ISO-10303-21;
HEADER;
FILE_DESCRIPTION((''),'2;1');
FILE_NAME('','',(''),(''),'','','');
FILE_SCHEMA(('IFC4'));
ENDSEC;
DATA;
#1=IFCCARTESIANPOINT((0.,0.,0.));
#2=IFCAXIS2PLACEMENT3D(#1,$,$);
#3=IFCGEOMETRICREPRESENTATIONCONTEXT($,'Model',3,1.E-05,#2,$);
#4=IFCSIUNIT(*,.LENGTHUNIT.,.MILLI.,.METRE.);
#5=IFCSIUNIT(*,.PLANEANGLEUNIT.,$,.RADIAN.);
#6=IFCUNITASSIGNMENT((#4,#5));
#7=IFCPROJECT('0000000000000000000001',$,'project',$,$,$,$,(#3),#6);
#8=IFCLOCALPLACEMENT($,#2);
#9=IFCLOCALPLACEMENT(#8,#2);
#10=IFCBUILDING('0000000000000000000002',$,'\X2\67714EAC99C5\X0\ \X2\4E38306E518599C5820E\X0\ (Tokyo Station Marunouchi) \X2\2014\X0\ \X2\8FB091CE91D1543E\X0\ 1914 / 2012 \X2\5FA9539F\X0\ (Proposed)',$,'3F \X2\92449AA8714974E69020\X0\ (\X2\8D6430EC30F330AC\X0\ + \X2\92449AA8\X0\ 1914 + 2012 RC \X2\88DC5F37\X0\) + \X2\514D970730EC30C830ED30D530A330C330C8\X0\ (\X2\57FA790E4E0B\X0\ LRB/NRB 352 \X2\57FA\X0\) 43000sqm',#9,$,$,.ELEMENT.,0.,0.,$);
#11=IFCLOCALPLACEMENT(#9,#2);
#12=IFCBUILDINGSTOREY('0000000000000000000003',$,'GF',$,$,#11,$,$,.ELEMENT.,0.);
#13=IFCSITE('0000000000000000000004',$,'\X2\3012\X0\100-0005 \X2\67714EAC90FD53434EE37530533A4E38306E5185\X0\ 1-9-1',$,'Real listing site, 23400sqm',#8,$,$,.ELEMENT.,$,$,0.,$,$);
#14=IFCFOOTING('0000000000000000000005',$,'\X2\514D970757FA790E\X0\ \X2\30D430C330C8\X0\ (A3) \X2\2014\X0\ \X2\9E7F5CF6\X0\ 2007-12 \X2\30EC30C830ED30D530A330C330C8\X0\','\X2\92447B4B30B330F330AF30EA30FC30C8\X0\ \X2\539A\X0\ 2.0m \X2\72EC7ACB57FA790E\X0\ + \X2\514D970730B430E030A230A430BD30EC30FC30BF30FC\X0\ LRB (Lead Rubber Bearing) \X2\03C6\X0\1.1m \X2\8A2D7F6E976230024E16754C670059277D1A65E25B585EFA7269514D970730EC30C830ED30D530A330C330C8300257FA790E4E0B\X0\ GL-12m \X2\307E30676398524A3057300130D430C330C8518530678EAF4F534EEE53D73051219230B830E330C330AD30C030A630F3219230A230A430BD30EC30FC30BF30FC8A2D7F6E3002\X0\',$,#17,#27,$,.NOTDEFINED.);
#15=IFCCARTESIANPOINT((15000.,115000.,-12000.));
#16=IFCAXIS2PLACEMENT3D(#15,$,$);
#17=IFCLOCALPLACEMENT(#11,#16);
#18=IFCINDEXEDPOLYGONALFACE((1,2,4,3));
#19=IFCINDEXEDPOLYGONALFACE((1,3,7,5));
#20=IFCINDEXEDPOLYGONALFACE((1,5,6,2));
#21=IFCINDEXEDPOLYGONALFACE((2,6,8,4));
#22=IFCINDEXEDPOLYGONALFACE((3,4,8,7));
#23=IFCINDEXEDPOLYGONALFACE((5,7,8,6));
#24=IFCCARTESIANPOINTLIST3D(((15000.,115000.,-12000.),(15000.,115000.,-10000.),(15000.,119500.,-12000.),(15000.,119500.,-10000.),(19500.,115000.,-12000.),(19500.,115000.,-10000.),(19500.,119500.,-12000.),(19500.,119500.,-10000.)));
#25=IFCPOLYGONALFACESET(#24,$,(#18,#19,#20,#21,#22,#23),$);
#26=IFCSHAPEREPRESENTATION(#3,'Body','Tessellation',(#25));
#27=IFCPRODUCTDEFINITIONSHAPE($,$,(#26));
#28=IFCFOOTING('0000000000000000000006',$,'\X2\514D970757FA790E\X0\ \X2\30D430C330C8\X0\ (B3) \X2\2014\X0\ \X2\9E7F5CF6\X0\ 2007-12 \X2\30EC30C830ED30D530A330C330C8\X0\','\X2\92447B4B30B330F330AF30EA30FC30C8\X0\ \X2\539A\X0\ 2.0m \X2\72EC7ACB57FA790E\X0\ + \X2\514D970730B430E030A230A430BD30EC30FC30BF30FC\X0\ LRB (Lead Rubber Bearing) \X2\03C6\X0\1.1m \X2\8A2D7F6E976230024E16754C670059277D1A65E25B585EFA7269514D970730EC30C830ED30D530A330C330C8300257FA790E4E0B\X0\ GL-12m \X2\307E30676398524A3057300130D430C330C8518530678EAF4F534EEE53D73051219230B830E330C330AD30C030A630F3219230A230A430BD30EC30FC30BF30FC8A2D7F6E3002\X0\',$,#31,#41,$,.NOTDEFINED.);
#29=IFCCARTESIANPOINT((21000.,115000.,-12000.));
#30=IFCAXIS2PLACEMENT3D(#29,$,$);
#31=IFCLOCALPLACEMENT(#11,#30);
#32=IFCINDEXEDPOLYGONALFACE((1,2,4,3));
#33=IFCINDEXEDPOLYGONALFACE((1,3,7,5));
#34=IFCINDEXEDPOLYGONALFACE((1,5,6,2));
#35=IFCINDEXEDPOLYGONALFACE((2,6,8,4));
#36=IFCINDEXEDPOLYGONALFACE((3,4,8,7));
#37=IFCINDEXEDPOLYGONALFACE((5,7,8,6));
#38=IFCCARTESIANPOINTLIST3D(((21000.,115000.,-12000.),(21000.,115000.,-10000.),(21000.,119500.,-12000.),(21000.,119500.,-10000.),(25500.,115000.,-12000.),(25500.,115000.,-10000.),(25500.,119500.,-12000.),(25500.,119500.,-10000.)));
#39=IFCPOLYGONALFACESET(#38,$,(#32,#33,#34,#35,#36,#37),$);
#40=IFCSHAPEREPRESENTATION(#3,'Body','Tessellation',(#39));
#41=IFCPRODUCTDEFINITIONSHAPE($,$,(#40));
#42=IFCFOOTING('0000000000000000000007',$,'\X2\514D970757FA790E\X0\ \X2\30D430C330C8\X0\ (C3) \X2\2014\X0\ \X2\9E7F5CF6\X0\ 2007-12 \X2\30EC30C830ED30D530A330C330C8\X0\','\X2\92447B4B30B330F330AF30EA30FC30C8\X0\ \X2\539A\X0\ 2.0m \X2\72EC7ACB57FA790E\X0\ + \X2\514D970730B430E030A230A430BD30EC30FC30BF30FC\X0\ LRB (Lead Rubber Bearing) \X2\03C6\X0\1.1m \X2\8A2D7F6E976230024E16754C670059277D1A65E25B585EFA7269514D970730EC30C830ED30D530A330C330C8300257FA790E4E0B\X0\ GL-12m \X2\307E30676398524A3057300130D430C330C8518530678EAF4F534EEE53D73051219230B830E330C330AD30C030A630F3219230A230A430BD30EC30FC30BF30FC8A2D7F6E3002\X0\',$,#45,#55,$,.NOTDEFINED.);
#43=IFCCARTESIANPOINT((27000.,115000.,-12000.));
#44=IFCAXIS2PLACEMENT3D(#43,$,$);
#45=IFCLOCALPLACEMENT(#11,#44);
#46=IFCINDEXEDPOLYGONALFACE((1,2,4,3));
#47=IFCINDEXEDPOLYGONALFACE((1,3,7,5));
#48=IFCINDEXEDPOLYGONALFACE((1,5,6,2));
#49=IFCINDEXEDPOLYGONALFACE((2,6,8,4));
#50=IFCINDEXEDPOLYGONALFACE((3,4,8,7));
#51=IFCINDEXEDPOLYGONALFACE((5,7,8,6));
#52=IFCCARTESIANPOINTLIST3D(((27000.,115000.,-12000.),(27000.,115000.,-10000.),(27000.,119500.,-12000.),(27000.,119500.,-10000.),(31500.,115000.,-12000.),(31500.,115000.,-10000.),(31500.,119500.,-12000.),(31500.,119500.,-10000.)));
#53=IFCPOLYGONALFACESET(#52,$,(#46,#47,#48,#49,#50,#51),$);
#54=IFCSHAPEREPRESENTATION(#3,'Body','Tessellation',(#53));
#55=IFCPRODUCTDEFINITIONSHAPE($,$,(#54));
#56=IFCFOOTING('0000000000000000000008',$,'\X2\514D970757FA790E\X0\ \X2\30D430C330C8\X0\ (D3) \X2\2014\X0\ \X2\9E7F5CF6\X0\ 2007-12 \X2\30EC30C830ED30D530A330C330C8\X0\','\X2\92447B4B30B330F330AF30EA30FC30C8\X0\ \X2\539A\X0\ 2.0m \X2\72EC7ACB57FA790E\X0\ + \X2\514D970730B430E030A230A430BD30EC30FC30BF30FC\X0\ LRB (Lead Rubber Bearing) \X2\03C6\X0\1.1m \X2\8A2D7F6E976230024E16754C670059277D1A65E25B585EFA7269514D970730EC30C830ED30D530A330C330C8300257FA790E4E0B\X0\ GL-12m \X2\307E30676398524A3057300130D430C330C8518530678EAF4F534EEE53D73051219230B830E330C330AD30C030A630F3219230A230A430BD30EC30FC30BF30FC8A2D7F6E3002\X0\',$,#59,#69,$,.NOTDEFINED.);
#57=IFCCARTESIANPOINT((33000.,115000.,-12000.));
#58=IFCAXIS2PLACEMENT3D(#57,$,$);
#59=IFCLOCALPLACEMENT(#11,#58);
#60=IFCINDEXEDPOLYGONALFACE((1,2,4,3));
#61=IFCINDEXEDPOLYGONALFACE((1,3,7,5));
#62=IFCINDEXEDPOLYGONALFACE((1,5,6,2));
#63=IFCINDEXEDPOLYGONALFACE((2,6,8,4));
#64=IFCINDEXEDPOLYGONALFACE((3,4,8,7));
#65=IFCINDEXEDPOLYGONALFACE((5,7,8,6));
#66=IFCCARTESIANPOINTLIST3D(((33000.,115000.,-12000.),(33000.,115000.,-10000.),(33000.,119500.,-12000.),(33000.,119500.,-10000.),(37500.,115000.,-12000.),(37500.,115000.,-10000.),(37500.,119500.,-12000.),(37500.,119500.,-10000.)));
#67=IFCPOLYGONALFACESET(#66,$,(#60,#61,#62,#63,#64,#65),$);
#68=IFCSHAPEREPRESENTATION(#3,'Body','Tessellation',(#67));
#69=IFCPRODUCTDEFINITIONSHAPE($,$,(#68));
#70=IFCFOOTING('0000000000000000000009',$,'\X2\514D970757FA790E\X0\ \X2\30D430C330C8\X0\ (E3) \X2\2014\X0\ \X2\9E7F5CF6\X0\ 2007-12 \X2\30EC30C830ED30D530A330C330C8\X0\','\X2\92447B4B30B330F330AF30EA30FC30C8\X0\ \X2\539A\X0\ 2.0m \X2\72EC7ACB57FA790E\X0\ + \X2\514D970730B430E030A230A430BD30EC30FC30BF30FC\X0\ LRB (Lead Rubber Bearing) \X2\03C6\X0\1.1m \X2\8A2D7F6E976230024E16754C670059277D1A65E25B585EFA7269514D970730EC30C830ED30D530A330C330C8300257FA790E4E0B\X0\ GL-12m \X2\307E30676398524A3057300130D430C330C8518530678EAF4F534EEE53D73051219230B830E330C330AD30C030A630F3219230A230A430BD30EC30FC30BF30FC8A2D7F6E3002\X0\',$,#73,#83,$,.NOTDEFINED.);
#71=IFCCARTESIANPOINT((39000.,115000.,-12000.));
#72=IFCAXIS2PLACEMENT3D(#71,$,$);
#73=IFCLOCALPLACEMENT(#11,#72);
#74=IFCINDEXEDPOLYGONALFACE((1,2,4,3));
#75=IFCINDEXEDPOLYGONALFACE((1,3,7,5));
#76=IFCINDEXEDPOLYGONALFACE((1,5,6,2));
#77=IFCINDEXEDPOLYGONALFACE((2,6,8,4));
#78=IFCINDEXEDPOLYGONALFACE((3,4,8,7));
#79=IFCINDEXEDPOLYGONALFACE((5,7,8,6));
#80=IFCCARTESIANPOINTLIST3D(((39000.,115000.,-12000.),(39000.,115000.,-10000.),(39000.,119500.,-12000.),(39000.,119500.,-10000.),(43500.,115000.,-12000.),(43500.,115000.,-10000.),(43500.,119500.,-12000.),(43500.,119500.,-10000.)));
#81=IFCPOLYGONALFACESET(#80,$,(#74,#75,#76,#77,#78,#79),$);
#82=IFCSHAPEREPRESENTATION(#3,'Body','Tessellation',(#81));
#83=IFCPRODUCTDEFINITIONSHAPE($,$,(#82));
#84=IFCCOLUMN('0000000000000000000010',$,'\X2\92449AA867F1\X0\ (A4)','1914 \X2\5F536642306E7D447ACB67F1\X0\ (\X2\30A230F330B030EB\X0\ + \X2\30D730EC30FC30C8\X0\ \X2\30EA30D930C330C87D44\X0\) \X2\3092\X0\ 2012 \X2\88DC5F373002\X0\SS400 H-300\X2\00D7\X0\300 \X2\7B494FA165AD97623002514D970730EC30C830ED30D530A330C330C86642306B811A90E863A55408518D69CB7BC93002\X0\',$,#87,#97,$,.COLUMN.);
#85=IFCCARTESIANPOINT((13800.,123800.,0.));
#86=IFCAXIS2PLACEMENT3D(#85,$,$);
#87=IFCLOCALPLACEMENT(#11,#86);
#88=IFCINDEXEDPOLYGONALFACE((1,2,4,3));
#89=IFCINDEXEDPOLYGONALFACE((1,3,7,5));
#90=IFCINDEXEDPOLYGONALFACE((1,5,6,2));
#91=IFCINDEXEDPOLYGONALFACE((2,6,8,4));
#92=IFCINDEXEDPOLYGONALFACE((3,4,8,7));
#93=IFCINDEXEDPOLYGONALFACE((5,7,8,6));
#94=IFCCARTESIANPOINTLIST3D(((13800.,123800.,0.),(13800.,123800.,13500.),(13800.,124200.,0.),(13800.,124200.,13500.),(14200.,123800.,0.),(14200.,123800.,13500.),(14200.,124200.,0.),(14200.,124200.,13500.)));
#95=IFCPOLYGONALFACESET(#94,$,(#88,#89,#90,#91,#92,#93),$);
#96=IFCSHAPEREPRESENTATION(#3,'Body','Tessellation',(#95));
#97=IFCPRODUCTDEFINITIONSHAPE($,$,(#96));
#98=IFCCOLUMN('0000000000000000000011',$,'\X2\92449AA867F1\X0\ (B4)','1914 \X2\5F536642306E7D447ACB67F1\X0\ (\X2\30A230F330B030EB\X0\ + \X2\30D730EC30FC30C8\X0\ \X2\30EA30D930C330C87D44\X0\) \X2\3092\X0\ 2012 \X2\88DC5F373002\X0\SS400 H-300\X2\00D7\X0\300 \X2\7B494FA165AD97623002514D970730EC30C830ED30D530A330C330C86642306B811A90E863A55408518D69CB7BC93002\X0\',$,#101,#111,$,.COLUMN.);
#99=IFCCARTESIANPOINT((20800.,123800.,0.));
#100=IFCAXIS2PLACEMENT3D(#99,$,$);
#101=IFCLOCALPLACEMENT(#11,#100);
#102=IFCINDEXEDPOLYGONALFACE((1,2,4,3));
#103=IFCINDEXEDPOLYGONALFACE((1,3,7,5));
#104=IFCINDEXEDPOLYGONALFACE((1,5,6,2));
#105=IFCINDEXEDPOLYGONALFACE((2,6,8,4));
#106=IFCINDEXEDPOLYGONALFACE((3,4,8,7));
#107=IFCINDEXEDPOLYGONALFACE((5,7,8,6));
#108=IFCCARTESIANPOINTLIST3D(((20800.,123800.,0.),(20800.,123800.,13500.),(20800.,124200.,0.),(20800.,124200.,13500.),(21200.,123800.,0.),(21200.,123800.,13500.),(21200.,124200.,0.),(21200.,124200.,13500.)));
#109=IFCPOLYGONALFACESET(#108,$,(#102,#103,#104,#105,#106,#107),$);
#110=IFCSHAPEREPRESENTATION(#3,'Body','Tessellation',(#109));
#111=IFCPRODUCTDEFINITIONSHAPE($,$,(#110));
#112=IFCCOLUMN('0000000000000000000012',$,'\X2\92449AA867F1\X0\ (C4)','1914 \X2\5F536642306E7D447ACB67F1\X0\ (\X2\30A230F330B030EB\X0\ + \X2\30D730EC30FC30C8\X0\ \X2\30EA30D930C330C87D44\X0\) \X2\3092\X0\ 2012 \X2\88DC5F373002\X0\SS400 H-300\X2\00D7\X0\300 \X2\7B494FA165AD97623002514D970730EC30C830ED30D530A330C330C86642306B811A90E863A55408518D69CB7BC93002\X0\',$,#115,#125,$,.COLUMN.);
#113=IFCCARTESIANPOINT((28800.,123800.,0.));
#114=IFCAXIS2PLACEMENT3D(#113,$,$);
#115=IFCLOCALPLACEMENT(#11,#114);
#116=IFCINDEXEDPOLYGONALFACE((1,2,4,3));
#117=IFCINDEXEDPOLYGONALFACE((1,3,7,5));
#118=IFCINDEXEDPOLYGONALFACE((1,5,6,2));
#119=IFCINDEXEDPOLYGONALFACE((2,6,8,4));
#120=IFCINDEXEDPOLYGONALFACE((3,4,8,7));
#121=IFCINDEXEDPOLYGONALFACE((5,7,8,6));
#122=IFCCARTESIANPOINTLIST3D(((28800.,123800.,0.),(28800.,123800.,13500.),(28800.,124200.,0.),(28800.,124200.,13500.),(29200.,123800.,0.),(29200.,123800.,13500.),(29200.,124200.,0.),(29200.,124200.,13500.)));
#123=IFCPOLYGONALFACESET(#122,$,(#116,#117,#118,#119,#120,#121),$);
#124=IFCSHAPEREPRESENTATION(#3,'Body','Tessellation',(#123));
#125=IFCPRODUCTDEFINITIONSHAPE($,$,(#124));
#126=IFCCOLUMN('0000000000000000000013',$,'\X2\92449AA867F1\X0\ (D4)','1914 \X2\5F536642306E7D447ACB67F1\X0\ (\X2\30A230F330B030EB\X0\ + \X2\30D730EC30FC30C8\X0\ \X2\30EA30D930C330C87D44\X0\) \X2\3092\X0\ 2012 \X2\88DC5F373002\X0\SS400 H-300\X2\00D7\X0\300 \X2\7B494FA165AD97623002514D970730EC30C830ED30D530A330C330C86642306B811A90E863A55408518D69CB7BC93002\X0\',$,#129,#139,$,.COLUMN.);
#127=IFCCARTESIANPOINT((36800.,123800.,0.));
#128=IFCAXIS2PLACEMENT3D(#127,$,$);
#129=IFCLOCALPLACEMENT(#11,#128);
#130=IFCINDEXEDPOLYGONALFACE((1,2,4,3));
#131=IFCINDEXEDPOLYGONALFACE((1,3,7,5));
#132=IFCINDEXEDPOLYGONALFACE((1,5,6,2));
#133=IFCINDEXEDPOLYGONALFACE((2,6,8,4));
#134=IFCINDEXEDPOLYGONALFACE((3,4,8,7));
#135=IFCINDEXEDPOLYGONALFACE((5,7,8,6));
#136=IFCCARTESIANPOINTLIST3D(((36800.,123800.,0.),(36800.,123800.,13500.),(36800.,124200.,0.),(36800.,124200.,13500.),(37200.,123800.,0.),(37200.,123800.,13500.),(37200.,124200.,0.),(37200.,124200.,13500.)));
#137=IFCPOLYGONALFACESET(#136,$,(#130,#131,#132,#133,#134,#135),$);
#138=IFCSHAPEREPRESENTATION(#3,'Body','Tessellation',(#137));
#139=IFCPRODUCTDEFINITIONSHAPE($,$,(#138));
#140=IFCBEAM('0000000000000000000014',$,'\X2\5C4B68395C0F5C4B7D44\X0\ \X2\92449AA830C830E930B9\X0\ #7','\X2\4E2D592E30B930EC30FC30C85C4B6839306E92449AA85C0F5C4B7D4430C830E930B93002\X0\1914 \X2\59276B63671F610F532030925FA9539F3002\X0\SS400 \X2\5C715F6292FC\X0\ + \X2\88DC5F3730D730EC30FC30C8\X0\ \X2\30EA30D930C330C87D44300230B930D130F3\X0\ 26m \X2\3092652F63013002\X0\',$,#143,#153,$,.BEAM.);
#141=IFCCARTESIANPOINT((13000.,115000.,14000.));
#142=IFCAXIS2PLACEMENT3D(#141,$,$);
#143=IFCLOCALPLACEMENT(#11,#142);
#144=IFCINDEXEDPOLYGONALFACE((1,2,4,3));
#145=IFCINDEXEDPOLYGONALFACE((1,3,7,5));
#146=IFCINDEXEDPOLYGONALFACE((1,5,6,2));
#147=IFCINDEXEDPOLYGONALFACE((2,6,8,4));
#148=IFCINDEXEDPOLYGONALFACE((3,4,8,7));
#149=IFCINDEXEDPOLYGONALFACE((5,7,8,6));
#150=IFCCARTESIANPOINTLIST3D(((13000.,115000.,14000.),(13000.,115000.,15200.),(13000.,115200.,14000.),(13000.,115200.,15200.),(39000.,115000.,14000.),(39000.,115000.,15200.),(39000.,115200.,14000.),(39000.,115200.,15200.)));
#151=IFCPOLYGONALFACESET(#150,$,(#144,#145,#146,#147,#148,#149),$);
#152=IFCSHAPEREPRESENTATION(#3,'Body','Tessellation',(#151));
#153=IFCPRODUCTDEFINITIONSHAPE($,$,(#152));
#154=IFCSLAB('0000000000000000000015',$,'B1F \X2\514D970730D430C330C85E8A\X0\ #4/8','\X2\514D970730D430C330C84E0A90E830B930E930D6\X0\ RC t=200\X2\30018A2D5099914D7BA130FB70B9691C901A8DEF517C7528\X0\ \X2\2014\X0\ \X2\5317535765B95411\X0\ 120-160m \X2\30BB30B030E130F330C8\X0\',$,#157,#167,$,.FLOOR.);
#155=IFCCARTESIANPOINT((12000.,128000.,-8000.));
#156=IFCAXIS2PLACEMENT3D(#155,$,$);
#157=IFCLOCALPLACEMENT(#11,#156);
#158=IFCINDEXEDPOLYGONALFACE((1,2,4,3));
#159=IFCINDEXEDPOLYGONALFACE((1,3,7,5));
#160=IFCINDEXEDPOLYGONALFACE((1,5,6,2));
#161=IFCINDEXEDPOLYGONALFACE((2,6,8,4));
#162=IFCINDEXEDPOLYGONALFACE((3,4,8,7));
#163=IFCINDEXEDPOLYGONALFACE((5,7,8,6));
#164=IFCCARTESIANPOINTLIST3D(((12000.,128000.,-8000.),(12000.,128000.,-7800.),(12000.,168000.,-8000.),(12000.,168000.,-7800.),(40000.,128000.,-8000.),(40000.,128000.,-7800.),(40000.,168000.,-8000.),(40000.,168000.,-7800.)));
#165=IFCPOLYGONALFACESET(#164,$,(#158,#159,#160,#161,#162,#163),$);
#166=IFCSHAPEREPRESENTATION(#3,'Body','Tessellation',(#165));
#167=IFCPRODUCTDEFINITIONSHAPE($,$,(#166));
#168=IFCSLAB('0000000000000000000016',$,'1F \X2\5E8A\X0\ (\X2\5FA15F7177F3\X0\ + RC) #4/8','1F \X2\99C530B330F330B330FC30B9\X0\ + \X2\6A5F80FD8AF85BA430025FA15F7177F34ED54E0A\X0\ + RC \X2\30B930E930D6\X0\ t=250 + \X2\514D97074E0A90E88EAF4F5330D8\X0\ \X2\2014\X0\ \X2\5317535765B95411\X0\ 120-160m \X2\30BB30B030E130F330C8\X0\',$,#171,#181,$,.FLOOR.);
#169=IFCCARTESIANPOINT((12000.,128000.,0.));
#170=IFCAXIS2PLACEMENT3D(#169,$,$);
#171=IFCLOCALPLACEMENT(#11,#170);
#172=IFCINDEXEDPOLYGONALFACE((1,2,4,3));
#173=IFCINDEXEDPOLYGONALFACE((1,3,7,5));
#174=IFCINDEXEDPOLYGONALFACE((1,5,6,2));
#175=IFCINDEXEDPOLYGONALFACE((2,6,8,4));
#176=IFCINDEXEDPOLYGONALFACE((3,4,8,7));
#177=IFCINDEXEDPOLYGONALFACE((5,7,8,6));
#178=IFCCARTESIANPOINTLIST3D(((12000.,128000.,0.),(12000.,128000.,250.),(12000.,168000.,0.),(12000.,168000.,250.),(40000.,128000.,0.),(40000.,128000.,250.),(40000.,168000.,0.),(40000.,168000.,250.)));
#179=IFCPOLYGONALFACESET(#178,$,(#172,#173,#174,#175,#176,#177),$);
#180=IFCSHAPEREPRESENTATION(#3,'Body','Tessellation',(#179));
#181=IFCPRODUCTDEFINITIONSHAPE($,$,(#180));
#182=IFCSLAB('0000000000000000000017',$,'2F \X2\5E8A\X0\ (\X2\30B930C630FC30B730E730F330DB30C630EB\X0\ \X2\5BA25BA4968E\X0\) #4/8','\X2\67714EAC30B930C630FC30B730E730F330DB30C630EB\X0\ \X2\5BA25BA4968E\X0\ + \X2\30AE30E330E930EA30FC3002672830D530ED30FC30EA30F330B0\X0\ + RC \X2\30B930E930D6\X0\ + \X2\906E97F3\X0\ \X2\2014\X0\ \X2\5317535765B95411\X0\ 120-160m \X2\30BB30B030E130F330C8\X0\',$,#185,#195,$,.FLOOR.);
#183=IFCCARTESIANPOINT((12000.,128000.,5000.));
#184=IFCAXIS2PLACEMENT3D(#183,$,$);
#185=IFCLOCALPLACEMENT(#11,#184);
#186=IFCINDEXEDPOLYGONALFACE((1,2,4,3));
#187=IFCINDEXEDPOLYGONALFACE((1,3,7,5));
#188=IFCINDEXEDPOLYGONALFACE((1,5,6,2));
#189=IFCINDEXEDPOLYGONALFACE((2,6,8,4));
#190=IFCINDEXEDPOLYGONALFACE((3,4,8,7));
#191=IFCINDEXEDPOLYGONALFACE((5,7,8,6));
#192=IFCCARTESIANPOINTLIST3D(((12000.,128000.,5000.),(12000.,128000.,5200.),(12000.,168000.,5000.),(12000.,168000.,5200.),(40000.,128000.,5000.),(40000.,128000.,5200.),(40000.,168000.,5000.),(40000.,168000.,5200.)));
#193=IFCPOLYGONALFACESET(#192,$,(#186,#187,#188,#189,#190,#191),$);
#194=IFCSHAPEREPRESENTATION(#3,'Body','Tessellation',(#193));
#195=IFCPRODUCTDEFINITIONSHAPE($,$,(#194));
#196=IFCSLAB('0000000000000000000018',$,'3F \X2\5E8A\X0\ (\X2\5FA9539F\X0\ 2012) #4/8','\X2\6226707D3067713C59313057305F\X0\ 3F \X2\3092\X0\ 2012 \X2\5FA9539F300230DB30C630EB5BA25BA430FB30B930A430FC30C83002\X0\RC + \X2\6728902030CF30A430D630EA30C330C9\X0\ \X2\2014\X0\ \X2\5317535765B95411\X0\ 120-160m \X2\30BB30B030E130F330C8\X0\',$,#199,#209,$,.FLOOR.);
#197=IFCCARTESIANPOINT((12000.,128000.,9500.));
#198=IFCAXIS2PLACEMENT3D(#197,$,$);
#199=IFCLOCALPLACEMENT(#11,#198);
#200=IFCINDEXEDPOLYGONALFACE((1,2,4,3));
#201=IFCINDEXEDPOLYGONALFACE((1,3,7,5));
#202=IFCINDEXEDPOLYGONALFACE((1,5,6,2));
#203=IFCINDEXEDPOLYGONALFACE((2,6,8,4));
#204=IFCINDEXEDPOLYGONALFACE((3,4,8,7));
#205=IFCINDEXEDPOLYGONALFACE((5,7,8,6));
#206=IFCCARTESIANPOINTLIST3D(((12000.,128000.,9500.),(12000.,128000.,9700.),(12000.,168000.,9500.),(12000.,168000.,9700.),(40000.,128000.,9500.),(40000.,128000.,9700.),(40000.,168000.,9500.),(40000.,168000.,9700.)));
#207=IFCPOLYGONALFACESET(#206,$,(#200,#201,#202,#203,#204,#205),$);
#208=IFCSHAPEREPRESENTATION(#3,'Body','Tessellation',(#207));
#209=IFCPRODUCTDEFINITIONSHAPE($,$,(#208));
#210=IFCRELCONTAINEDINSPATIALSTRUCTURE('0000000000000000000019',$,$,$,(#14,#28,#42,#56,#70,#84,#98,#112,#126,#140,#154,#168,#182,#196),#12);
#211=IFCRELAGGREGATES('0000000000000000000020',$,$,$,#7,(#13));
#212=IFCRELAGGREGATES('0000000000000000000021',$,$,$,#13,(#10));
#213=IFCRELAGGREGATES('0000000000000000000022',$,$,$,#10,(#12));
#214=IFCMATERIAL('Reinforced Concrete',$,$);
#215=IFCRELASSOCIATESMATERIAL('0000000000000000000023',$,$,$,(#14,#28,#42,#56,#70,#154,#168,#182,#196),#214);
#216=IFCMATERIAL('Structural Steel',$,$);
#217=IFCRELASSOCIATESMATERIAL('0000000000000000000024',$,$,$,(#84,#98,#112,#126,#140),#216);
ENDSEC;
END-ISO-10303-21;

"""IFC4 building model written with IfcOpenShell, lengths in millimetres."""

from ifc_helpers import new_model, si_unit, frame, frame_2d, origin, place, context, project, spatial, rectangle, extrude, material, element, save


model = new_model("IFC4")

# Units and contexts
model_context = context("Model", 3, precision=1e-05, world=origin())
ifc_project = project(units=[si_unit("LENGTHUNIT", "METRE", prefix="MILLI"), si_unit("PLANEANGLEUNIT", "RADIAN")], contexts=[model_context])

# Site, building, storey
site_placement = place(None, origin())
site = spatial("IfcSite", under=ifc_project, at=site_placement, Name="〒100-0005 東京都千代田区丸の内 1-9-1", ObjectType="Real listing site, 23400sqm", CompositionType="ELEMENT", RefElevation=0.0)
building_placement = place(site_placement, origin())
building = spatial("IfcBuilding", under=site, at=building_placement, Name="東京駅 丸の内駅舎 (Tokyo Station Marunouchi) — 辰野金吾 1914 / 2012 復原 (Proposed)", ObjectType="3F 鉄骨煉瓦造 (赤レンガ + 鉄骨 1914 + 2012 RC 補強) + 免震レトロフィット (基礎下 LRB/NRB 352 基) 43000sqm", CompositionType="ELEMENT", ElevationOfRefHeight=0.0, ElevationOfTerrain=0.0)
storey_placement = place(building_placement, origin())
storey = spatial("IfcBuildingStorey", under=building, at=storey_placement, Name="GF", CompositionType="ELEMENT", Elevation=0.0)

# Footings
ifc_material_1 = material(Name="Reinforced Concrete")
footing_1_placement = place(storey_placement, frame((15000.0, 115000.0, -12000.0)))
element("IfcFooting", 1, at=footing_1_placement, inside=storey, material=ifc_material_1, Name="免震基礎 ピット (A3) — 鹿島 2007-12 レトロフィット", Description="鉄筋コンクリート 厚 2.0m 独立基礎 + 免震ゴムアイソレーター LRB (Lead Rubber Bearing) φ1.1m 設置面。世界最大級既存建物免震レトロフィット。基礎下 GL-12m まで掘削し、ピット内で躯体仮受け→ジャッキダウン→アイソレーター設置。", PredefinedType="NOTDEFINED", context=model_context, shape_type="SweptSolid", body=[
    extrude(rectangle(XDim=4500.0, YDim=4500.0, at=frame_2d((2250.0, 2250.0))), frame((15000.0, 115000.0, -12000.0)), (0.0, 0.0, 1.0), 2000.0),
])
footing_2_placement = place(storey_placement, frame((21000.0, 115000.0, -12000.0)))
element("IfcFooting", 2, at=footing_2_placement, inside=storey, material=ifc_material_1, Name="免震基礎 ピット (B3) — 鹿島 2007-12 レトロフィット", Description="鉄筋コンクリート 厚 2.0m 独立基礎 + 免震ゴムアイソレーター LRB (Lead Rubber Bearing) φ1.1m 設置面。世界最大級既存建物免震レトロフィット。基礎下 GL-12m まで掘削し、ピット内で躯体仮受け→ジャッキダウン→アイソレーター設置。", PredefinedType="NOTDEFINED", context=model_context, shape_type="SweptSolid", body=[
    extrude(rectangle(XDim=4500.0, YDim=4500.0, at=frame_2d((2250.0, 2250.0))), frame((21000.0, 115000.0, -12000.0)), (0.0, 0.0, 1.0), 2000.0),
])
footing_3_placement = place(storey_placement, frame((27000.0, 115000.0, -12000.0)))
element("IfcFooting", 3, at=footing_3_placement, inside=storey, material=ifc_material_1, Name="免震基礎 ピット (C3) — 鹿島 2007-12 レトロフィット", Description="鉄筋コンクリート 厚 2.0m 独立基礎 + 免震ゴムアイソレーター LRB (Lead Rubber Bearing) φ1.1m 設置面。世界最大級既存建物免震レトロフィット。基礎下 GL-12m まで掘削し、ピット内で躯体仮受け→ジャッキダウン→アイソレーター設置。", PredefinedType="NOTDEFINED", context=model_context, shape_type="SweptSolid", body=[
    extrude(rectangle(XDim=4500.0, YDim=4500.0, at=frame_2d((2250.0, 2250.0))), frame((27000.0, 115000.0, -12000.0)), (0.0, 0.0, 1.0), 2000.0),
])
footing_4_placement = place(storey_placement, frame((33000.0, 115000.0, -12000.0)))
element("IfcFooting", 4, at=footing_4_placement, inside=storey, material=ifc_material_1, Name="免震基礎 ピット (D3) — 鹿島 2007-12 レトロフィット", Description="鉄筋コンクリート 厚 2.0m 独立基礎 + 免震ゴムアイソレーター LRB (Lead Rubber Bearing) φ1.1m 設置面。世界最大級既存建物免震レトロフィット。基礎下 GL-12m まで掘削し、ピット内で躯体仮受け→ジャッキダウン→アイソレーター設置。", PredefinedType="NOTDEFINED", context=model_context, shape_type="SweptSolid", body=[
    extrude(rectangle(XDim=4500.0, YDim=4500.0, at=frame_2d((2250.0, 2250.0))), frame((33000.0, 115000.0, -12000.0)), (0.0, 0.0, 1.0), 2000.0),
])
footing_5_placement = place(storey_placement, frame((39000.0, 115000.0, -12000.0)))
element("IfcFooting", 5, at=footing_5_placement, inside=storey, material=ifc_material_1, Name="免震基礎 ピット (E3) — 鹿島 2007-12 レトロフィット", Description="鉄筋コンクリート 厚 2.0m 独立基礎 + 免震ゴムアイソレーター LRB (Lead Rubber Bearing) φ1.1m 設置面。世界最大級既存建物免震レトロフィット。基礎下 GL-12m まで掘削し、ピット内で躯体仮受け→ジャッキダウン→アイソレーター設置。", PredefinedType="NOTDEFINED", context=model_context, shape_type="SweptSolid", body=[
    extrude(rectangle(XDim=4500.0, YDim=4500.0, at=frame_2d((2250.0, 2250.0))), frame((39000.0, 115000.0, -12000.0)), (0.0, 0.0, 1.0), 2000.0),
])

# Columns
ifc_material_2 = material(Name="Structural Steel")
column_1_placement = place(storey_placement, frame((13800.0, 123800.0, 0.0)))
element("IfcColumn", 6, at=column_1_placement, inside=storey, material=ifc_material_2, Name="鉄骨柱 (A4)", Description="1914 当時の組立柱 (アングル + プレート リベット組) を 2012 補強。SS400 H-300×300 等価断面。免震レトロフィット時に脚部接合再構築。", PredefinedType="COLUMN", context=model_context, shape_type="SweptSolid", body=[
    extrude(rectangle(XDim=400.0, YDim=400.0, at=frame_2d((200.0, 200.0))), frame((13800.0, 123800.0, 0.0)), (0.0, 0.0, 1.0), 13500.0),
])
column_2_placement = place(storey_placement, frame((20800.0, 123800.0, 0.0)))
element("IfcColumn", 7, at=column_2_placement, inside=storey, material=ifc_material_2, Name="鉄骨柱 (B4)", Description="1914 当時の組立柱 (アングル + プレート リベット組) を 2012 補強。SS400 H-300×300 等価断面。免震レトロフィット時に脚部接合再構築。", PredefinedType="COLUMN", context=model_context, shape_type="SweptSolid", body=[
    extrude(rectangle(XDim=400.0, YDim=400.0, at=frame_2d((200.0, 200.0))), frame((20800.0, 123800.0, 0.0)), (0.0, 0.0, 1.0), 13500.0),
])
column_3_placement = place(storey_placement, frame((28800.0, 123800.0, 0.0)))
element("IfcColumn", 8, at=column_3_placement, inside=storey, material=ifc_material_2, Name="鉄骨柱 (C4)", Description="1914 当時の組立柱 (アングル + プレート リベット組) を 2012 補強。SS400 H-300×300 等価断面。免震レトロフィット時に脚部接合再構築。", PredefinedType="COLUMN", context=model_context, shape_type="SweptSolid", body=[
    extrude(rectangle(XDim=400.0, YDim=400.0, at=frame_2d((200.0, 200.0))), frame((28800.0, 123800.0, 0.0)), (0.0, 0.0, 1.0), 13500.0),
])
column_4_placement = place(storey_placement, frame((36800.0, 123800.0, 0.0)))
element("IfcColumn", 9, at=column_4_placement, inside=storey, material=ifc_material_2, Name="鉄骨柱 (D4)", Description="1914 当時の組立柱 (アングル + プレート リベット組) を 2012 補強。SS400 H-300×300 等価断面。免震レトロフィット時に脚部接合再構築。", PredefinedType="COLUMN", context=model_context, shape_type="SweptSolid", body=[
    extrude(rectangle(XDim=400.0, YDim=400.0, at=frame_2d((200.0, 200.0))), frame((36800.0, 123800.0, 0.0)), (0.0, 0.0, 1.0), 13500.0),
])

# Beam
beam_placement = place(storey_placement, frame((13000.0, 115000.0, 14000.0)))
element("IfcBeam", 10, at=beam_placement, inside=storey, material=ifc_material_2, Name="屋根小屋組 鉄骨トラス #7", Description="中央スレート屋根の鉄骨小屋組トラス。1914 大正期意匠を復原。SS400 山形鋼 + 補強プレート リベット組。スパン 26m を支持。", PredefinedType="BEAM", context=model_context, shape_type="SweptSolid", body=[
    extrude(rectangle(XDim=26000.0, YDim=200.0, at=frame_2d((13000.0, 100.0))), frame((13000.0, 115000.0, 14000.0)), (0.0, 0.0, 1.0), 1200.0),
])

# Slabs
slab_1_placement = place(storey_placement, frame((12000.0, 128000.0, -8000.0)))
element("IfcSlab", 11, at=slab_1_placement, inside=storey, material=ifc_material_1, Name="B1F 免震ピット床 #4/8", Description="免震ピット上部スラブ RC t=200、設備配管・点検通路兼用 — 北南方向 120-160m セグメント", PredefinedType="FLOOR", context=model_context, shape_type="SweptSolid", body=[
    extrude(rectangle(XDim=28000.0, YDim=40000.0, at=frame_2d((14000.0, 20000.0))), frame((12000.0, 128000.0, -8000.0)), (0.0, 0.0, 1.0), 200.0),
])
slab_2_placement = place(storey_placement, frame((12000.0, 128000.0, 0.0)))
element("IfcSlab", 12, at=slab_2_placement, inside=storey, material=ifc_material_1, Name="1F 床 (御影石 + RC) #4/8", Description="1F 駅コンコース + 機能諸室。御影石仕上 + RC スラブ t=250 + 免震上部躯体ヘ — 北南方向 120-160m セグメント", PredefinedType="FLOOR", context=model_context, shape_type="SweptSolid", body=[
    extrude(rectangle(XDim=28000.0, YDim=40000.0, at=frame_2d((14000.0, 20000.0))), frame((12000.0, 128000.0, 0.0)), (0.0, 0.0, 1.0), 250.0),
])
slab_3_placement = place(storey_placement, frame((12000.0, 128000.0, 5000.0)))
element("IfcSlab", 13, at=slab_3_placement, inside=storey, material=ifc_material_1, Name="2F 床 (ステーションホテル 客室階) #4/8", Description="東京ステーションホテル 客室階 + ギャラリー。木フローリング + RC スラブ + 遮音 — 北南方向 120-160m セグメント", PredefinedType="FLOOR", context=model_context, shape_type="SweptSolid", body=[
    extrude(rectangle(XDim=28000.0, YDim=40000.0, at=frame_2d((14000.0, 20000.0))), frame((12000.0, 128000.0, 5000.0)), (0.0, 0.0, 1.0), 200.0),
])
slab_4_placement = place(storey_placement, frame((12000.0, 128000.0, 9500.0)))
element("IfcSlab", 14, at=slab_4_placement, inside=storey, material=ifc_material_1, Name="3F 床 (復原 2012) #4/8", Description="戦災で焼失した 3F を 2012 復原。ホテル客室・スイート。RC + 木造ハイブリッド — 北南方向 120-160m セグメント", PredefinedType="FLOOR", context=model_context, shape_type="SweptSolid", body=[
    extrude(rectangle(XDim=28000.0, YDim=40000.0, at=frame_2d((14000.0, 20000.0))), frame((12000.0, 128000.0, 9500.0)), (0.0, 0.0, 1.0), 200.0),
])

save(model, "model.ifc")
